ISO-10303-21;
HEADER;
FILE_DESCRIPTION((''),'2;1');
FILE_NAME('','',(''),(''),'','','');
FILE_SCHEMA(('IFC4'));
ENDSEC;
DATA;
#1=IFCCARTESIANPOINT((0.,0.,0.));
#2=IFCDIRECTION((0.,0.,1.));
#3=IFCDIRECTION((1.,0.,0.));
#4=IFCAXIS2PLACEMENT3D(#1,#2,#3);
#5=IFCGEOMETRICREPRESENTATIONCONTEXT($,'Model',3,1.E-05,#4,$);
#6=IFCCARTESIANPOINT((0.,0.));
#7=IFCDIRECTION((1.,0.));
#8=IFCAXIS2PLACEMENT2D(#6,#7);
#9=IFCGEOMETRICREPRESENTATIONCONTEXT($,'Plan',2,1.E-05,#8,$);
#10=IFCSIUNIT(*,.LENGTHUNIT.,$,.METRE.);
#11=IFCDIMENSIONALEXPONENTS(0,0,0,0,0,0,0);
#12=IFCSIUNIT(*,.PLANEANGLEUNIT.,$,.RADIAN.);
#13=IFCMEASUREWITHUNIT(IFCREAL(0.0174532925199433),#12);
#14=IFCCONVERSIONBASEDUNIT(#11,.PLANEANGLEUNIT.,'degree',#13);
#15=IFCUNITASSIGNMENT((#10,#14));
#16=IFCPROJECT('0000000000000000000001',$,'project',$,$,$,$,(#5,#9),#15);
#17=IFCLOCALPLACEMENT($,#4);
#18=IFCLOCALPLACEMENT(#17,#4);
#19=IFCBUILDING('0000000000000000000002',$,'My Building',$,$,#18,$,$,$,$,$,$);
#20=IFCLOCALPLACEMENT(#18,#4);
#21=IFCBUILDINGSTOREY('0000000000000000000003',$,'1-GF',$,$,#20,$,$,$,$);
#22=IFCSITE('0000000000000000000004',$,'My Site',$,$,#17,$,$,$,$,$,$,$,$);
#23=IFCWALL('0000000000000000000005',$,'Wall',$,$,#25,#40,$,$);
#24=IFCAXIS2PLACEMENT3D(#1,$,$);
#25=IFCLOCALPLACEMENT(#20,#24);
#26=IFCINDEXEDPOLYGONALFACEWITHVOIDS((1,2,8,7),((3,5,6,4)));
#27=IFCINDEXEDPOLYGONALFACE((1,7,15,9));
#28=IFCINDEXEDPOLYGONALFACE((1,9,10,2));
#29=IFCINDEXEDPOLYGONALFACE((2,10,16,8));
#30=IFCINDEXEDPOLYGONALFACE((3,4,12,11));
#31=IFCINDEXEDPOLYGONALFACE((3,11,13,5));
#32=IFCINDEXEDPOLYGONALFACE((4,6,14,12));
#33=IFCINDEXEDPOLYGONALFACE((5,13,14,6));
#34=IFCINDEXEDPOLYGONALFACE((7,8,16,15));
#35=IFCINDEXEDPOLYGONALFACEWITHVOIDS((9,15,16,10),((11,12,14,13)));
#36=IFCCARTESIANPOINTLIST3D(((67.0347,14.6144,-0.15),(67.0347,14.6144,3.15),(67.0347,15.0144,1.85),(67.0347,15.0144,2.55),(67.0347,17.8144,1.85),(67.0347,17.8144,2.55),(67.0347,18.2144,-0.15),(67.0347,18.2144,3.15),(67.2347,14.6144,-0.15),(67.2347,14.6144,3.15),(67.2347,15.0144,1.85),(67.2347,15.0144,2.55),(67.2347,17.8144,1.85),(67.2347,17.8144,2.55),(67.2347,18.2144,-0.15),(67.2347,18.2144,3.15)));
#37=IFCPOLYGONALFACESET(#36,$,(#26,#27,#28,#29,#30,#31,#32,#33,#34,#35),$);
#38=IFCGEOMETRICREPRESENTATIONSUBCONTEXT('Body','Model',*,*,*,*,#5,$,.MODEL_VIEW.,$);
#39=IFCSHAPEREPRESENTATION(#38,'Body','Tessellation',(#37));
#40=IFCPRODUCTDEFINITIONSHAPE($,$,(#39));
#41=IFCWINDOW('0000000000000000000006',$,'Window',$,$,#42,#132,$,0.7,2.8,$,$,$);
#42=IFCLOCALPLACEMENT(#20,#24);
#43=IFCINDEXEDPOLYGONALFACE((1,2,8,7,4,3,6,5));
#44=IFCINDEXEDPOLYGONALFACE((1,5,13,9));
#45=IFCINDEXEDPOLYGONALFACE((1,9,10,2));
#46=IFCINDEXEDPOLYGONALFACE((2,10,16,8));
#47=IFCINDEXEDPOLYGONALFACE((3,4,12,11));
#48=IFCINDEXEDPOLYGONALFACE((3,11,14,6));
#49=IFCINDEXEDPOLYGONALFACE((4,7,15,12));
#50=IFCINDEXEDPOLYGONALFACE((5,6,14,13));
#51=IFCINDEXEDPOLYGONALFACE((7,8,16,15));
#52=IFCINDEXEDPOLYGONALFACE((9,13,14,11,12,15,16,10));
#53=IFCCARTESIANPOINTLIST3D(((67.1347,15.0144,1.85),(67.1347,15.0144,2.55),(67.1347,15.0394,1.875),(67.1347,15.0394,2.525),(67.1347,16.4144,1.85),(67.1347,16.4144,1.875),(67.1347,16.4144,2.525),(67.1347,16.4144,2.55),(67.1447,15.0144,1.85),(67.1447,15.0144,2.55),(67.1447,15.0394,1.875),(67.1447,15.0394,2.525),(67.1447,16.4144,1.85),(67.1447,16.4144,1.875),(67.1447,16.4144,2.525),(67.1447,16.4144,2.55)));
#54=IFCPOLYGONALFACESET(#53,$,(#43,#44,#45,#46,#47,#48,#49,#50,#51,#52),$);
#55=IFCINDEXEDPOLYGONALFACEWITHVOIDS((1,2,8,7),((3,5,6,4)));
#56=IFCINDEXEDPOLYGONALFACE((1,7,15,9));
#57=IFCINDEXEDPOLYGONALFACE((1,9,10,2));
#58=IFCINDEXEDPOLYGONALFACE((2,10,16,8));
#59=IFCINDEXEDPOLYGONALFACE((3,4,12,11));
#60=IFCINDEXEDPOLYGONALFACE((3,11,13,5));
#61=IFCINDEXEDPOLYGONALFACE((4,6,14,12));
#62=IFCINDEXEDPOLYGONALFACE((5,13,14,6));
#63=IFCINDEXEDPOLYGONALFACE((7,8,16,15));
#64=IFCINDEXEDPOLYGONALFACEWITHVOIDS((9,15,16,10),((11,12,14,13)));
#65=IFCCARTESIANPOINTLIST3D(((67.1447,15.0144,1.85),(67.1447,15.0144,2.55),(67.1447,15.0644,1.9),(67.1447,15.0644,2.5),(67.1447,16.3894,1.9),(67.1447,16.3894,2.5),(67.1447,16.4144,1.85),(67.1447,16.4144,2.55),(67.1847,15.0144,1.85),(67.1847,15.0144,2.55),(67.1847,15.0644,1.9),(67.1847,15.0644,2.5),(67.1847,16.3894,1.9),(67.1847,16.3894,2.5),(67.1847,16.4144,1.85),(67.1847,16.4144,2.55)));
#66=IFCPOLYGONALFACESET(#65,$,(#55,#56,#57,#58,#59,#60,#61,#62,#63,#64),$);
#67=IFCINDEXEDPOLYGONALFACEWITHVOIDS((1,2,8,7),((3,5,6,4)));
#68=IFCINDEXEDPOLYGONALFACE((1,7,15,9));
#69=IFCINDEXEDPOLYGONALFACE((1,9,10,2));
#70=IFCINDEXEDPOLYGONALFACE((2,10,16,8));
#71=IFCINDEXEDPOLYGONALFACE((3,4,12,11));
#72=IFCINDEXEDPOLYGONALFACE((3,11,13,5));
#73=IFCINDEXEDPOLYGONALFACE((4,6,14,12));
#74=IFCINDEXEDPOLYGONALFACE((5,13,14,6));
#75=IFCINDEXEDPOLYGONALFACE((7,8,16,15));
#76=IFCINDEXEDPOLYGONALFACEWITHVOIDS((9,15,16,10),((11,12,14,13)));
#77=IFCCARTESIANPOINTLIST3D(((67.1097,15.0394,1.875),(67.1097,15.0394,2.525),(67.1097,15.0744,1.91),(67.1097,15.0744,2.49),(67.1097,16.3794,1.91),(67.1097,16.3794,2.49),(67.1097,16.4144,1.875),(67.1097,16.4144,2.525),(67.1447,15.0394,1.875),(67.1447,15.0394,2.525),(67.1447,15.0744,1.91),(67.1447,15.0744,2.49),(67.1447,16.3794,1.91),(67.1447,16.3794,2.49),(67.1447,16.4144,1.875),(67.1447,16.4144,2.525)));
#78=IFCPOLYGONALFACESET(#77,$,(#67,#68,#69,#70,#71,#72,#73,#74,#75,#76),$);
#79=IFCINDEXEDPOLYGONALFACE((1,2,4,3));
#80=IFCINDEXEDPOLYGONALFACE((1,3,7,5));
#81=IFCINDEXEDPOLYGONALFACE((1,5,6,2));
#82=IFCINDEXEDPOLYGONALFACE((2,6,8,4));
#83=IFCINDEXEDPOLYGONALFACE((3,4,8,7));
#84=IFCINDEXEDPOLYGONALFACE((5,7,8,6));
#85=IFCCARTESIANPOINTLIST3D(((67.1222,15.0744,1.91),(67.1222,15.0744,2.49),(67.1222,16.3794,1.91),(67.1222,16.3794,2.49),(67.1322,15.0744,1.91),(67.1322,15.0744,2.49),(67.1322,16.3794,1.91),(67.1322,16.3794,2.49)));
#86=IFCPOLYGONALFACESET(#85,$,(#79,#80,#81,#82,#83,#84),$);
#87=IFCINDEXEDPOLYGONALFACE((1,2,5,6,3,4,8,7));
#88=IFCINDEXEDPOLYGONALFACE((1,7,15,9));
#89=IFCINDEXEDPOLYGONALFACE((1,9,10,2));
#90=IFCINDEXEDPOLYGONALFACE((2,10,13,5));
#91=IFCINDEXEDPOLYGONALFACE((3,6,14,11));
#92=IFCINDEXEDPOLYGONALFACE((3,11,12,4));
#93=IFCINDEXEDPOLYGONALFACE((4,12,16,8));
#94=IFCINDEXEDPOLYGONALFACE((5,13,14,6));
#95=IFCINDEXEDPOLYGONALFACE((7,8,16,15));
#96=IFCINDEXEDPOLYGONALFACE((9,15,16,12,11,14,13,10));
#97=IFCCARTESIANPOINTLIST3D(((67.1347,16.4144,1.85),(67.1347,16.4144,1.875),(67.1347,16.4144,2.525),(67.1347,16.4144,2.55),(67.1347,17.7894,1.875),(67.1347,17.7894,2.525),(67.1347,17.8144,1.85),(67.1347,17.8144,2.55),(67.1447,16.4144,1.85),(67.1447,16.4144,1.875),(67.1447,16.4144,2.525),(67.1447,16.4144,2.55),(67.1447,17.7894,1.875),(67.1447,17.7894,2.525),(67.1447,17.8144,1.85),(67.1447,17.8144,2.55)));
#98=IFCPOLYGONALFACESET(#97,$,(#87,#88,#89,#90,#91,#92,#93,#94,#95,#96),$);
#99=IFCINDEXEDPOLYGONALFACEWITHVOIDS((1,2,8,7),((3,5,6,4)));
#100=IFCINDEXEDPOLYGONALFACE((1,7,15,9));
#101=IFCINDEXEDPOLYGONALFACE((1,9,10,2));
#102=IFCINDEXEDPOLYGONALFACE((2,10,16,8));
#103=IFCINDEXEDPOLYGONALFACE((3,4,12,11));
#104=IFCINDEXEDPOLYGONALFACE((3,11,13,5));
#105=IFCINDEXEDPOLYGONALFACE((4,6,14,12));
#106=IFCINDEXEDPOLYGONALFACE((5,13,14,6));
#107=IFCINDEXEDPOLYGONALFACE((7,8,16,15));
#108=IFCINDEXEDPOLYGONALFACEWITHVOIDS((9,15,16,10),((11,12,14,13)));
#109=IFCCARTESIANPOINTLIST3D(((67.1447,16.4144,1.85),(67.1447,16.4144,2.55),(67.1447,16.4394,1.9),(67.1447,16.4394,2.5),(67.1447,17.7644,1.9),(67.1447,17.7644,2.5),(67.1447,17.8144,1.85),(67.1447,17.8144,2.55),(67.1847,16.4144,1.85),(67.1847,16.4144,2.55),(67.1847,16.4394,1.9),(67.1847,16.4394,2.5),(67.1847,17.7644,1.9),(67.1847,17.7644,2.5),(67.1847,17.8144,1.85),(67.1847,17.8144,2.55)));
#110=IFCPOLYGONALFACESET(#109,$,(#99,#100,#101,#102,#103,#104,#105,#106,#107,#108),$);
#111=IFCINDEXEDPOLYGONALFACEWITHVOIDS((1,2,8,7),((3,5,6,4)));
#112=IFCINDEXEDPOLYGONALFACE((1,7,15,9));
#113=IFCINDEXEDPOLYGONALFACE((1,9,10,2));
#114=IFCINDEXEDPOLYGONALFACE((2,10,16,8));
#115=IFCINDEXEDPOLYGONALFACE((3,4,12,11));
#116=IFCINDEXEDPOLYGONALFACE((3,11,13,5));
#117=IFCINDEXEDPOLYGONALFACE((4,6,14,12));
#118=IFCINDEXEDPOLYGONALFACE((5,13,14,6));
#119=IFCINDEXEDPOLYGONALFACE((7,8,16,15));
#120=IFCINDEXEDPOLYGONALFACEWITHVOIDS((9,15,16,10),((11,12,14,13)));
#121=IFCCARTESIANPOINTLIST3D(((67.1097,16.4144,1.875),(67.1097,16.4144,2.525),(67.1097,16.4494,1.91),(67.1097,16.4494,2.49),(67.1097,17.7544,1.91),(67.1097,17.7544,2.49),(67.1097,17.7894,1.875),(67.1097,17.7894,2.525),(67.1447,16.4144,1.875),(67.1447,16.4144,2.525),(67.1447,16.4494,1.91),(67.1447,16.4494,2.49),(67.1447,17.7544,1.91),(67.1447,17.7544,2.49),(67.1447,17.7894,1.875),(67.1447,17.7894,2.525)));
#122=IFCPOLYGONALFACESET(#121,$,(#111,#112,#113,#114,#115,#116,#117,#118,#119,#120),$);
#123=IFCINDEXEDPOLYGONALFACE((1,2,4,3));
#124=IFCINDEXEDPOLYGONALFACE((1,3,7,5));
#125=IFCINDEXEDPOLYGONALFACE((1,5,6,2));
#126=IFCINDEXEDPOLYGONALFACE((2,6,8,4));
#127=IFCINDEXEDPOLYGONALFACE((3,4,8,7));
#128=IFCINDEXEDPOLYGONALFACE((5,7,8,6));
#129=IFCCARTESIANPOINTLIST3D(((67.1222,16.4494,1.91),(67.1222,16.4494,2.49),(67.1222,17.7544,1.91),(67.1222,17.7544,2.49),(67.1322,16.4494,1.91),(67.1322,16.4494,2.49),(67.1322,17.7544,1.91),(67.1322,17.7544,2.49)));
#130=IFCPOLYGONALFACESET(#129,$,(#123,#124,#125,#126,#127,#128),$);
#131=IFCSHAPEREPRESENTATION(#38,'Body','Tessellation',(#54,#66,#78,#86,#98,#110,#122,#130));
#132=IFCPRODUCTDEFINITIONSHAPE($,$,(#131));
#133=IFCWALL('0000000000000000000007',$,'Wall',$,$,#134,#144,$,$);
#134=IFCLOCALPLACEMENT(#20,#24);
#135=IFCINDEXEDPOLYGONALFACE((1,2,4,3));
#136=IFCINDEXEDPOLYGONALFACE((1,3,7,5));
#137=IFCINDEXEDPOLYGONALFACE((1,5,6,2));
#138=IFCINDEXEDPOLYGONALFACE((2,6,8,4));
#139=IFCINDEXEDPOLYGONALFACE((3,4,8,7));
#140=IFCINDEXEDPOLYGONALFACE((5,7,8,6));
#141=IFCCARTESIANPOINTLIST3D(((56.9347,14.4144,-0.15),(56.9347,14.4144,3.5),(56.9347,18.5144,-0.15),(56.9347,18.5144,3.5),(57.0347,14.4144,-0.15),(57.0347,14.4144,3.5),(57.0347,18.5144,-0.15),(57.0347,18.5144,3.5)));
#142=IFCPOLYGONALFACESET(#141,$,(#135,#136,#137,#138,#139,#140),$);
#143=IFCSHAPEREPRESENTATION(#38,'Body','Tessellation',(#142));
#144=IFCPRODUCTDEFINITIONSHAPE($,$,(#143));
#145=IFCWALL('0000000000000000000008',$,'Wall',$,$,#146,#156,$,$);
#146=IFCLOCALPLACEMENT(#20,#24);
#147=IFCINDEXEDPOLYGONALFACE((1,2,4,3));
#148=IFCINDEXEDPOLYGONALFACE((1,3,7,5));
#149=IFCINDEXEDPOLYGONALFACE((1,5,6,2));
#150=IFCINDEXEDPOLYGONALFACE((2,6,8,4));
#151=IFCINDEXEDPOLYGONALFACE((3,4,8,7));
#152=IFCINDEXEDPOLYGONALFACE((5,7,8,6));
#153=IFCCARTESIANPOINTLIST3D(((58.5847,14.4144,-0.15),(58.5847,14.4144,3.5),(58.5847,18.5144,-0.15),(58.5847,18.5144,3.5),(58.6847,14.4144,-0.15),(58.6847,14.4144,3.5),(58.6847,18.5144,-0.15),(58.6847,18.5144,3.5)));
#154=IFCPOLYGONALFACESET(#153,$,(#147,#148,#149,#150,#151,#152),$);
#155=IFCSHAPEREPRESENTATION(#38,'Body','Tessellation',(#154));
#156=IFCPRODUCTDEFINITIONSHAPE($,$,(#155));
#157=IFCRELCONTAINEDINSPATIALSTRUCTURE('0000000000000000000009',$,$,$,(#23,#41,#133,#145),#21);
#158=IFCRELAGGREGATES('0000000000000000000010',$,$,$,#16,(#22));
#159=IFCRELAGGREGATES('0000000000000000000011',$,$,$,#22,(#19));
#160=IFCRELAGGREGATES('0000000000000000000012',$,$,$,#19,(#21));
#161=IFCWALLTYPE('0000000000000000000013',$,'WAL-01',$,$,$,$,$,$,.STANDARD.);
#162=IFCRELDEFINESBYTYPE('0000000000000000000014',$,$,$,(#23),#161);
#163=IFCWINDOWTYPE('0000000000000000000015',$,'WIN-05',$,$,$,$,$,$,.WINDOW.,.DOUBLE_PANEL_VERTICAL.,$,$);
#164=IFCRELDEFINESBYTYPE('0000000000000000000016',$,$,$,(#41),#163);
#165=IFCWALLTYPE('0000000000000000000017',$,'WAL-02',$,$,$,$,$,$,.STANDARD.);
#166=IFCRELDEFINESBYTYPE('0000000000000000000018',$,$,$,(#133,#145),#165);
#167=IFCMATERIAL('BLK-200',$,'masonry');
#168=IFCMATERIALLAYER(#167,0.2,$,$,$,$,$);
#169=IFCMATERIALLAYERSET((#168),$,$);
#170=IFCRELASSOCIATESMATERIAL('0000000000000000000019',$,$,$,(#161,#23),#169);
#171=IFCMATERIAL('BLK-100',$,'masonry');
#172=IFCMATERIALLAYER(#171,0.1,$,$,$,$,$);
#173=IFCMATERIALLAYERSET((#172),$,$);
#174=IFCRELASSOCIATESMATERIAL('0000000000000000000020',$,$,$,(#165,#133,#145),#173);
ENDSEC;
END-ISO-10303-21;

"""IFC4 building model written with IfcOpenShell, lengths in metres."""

from ifc_helpers import new_model, entity, si_unit, converted_unit, frame, origin_with_axes, origin_2d_with_axis, place, context, subcontext, project, spatial, line, indexed_curve, outline, extrude, shape, source, transform, mapped, material, layer, layer_set, layer_usage, type_object, type_shapes, element, fill, save


model = new_model("IFC4")

# Units and contexts
model_context = context("Model", 3, precision=1e-05, world=origin_with_axes())
plan_context = context("Plan", 2, precision=1e-05, world=origin_2d_with_axis())
body_context_1 = subcontext(model_context, "Body", "Model", "MODEL_VIEW")
body_context_2 = subcontext(plan_context, "Body", "Plan", "PLAN_VIEW")
ifc_project = project(units=[si_unit("LENGTHUNIT", "METRE"), converted_unit("PLANEANGLEUNIT", "degree", entity("IfcReal", 0.0174532925199433), si_unit("PLANEANGLEUNIT", "RADIAN"), dimensions=[0, 0, 0, 0, 0, 0, 0])], contexts=[model_context, plan_context])

# Site, building, storey
site_placement = place(None, origin_with_axes())
site = spatial("IfcSite", under=ifc_project, at=site_placement, Name="My Site")
building_placement = place(site_placement, origin_with_axes())
building = spatial("IfcBuilding", under=site, at=building_placement, Name="My Building")
storey_placement = place(building_placement, origin_with_axes())
storey = spatial("IfcBuildingStorey", under=building, at=storey_placement, Name="1-GF")

# Shared definitions
ifc_material_1 = material(Name="BLK-200", Category="masonry")
ifc_layer_1 = layer(ifc_material_1, 0.2)
ifc_layer_set_1 = layer_set([ifc_layer_1])
wall_type_1 = type_object("IfcWallType", Name="WAL-01", PredefinedType="STANDARD", material=ifc_layer_set_1)

# Wall, opening, window
ifc_layer_usage_1 = layer_usage(ifc_layer_set_1, "AXIS2", "POSITIVE", 0.0)
wall_1_placement = place(storey_placement, frame((67.2347, 14.6144, -0.15), z_axis=(0.0, 0.0, 1.0), x_axis=(0.000001, 1.0, 0.0)))
wall_1 = element("IfcWall", 1, at=wall_1_placement, inside=storey, type_object=wall_type_1, material=ifc_layer_usage_1, Name="Wall", context=body_context_1, shape_type="SweptSolid", body=[
    extrude(outline(indexed_curve([(0.0, 0.0), (0.0, 0.2), (3.6, 0.2), (3.6, 0.0), (0.0, 0.0)], self_intersect=False)), origin_with_axes(), (0.0, 0.0, 1.0), 3.3),
])
shared_shape_1 = source(origin_with_axes(), body_context_1, "Body", "SweptSolid", [
    extrude(outline(indexed_curve([(0.0, 0.0), (2.8, 0.0), (2.8, 0.7), (0.0, 0.7)], segments=[line(1, 2, 3, 4, 1)])), frame((0.0, -0.6, 0.0), z_axis=(0.0, -1.0, 0.0), x_axis=(1.0, 0.0, 0.0)), (0.0, 0.0, -1.0), 1.2),
])
opening_1_placement = place(wall_1_placement, frame((0.4, 0.0, 2.0), z_axis=(0.0, 0.0, 1.0), x_axis=(1.0, 0.0, 0.0)))
opening_1 = element("IfcOpeningElement", 2, at=opening_1_placement, cuts=wall_1, PredefinedType="OPENING", context=body_context_1, shape_type="MappedRepresentation", body=[
    mapped(shared_shape_1, transform((0.0, 0.0, 0.0), x_axis=(1.0, 0.0, 0.0), y_axis=(0.0, 1.0, 0.0), z_axis=(0.0, 0.0, 1.0), scale=1.0)),
])
window_type = type_object("IfcWindowType", Name="WIN-05", PartitioningType="DOUBLE_PANEL_VERTICAL", PredefinedType="WINDOW")
shared_shape_2 = source(origin_with_axes(), body_context_1, "Body", "SweptSolid", [
    extrude(outline(indexed_curve([(1.4, 0.0), (0.0, 0.0), (0.0, 0.7), (1.4, 0.7), (1.4, 0.675), (0.025, 0.675), (0.025, 0.025), (1.4, 0.025)], segments=[line(1, 2, 3, 4, 5, 6, 7, 8, 1)])), frame((0.0, 0.09, 0.0), z_axis=(0.0, -1.0, 0.0), x_axis=(1.0, 0.0, 0.0)), (0.0, 0.0, -1.0), 0.01),
    extrude(outline(indexed_curve([(0.0, 0.0), (1.4, 0.0), (1.4, 0.7), (0.0, 0.7)], segments=[line(1, 2, 3, 4, 1)]), holes=[indexed_curve([(0.05, 0.05), (1.375, 0.05), (1.375, 0.65), (0.05, 0.65)], segments=[line(1, 2, 3, 4, 1)])]), frame((0.0, 0.05, 0.0), z_axis=(0.0, -1.0, 0.0), x_axis=(1.0, 0.0, 0.0)), (0.0, 0.0, -1.0), 0.04),
    extrude(outline(indexed_curve([(0.0, 0.0), (1.375, 0.0), (1.375, 0.65), (0.0, 0.65)], segments=[line(1, 2, 3, 4, 1)]), holes=[indexed_curve([(0.035, 0.035), (1.34, 0.035), (1.34, 0.615), (0.035, 0.615)], segments=[line(1, 2, 3, 4, 1)])]), frame((0.025, 0.09, 0.025), z_axis=(0.0, -1.0, 0.0), x_axis=(1.0, 0.0, 0.0)), (0.0, 0.0, -1.0), 0.035),
    extrude(outline(indexed_curve([(0.035, 0.035), (1.34, 0.035), (1.34, 0.615), (0.035, 0.615)], segments=[line(1, 2, 3, 4, 1)])), frame((0.025, 0.1025, 0.025), z_axis=(0.0, -1.0, 0.0), x_axis=(1.0, 0.0, 0.0)), (0.0, 0.0, -1.0), 0.01),
    extrude(outline(indexed_curve([(0.0, 0.7), (1.4, 0.7), (1.4, 0.0), (0.0, 0.0), (0.0, 0.025), (1.375, 0.025), (1.375, 0.675), (0.0, 0.675)], segments=[line(1, 2, 3, 4, 5, 6, 7, 8, 1)])), frame((1.4, 0.09, 0.0), z_axis=(0.0, -1.0, 0.0), x_axis=(1.0, 0.0, 0.0)), (0.0, 0.0, -1.0), 0.01),
    extrude(outline(indexed_curve([(0.0, 0.0), (1.4, 0.0), (1.4, 0.7), (0.0, 0.7)], segments=[line(1, 2, 3, 4, 1)]), holes=[indexed_curve([(0.025, 0.05), (1.35, 0.05), (1.35, 0.65), (0.025, 0.65)], segments=[line(1, 2, 3, 4, 1)])]), frame((1.4, 0.05, 0.0), z_axis=(0.0, -1.0, 0.0), x_axis=(1.0, 0.0, 0.0)), (0.0, 0.0, -1.0), 0.04),
    extrude(outline(indexed_curve([(0.0, 0.0), (1.375, 0.0), (1.375, 0.65), (0.0, 0.65)], segments=[line(1, 2, 3, 4, 1)]), holes=[indexed_curve([(0.035, 0.035), (1.34, 0.035), (1.34, 0.615), (0.035, 0.615)], segments=[line(1, 2, 3, 4, 1)])]), frame((1.4, 0.09, 0.025), z_axis=(0.0, -1.0, 0.0), x_axis=(1.0, 0.0, 0.0)), (0.0, 0.0, -1.0), 0.035),
    extrude(outline(indexed_curve([(0.035, 0.035), (1.34, 0.035), (1.34, 0.615), (0.035, 0.615)], segments=[line(1, 2, 3, 4, 1)])), frame((1.4, 0.1025, 0.025), z_axis=(0.0, -1.0, 0.0), x_axis=(1.0, 0.0, 0.0)), (0.0, 0.0, -1.0), 0.01),
])
shared_shape_3 = source(origin_with_axes(), body_context_2, "Body", "Curve2D", [
    entity("IfcIndexedPolyCurve", entity("IfcCartesianPointList2D", [[0.05, 0.05], [1.375, 0.05]])),
    entity("IfcIndexedPolyCurve", entity("IfcCartesianPointList2D", [[0.0, 0.1], [0.025, 0.1], [0.025, 0.09], [0.05, 0.09], [0.05, 0.05], [0.0, 0.05]]), [entity("IfcLineIndex", [1, 2, 3, 4, 5, 6, 1])]),
    entity("IfcIndexedPolyCurve", entity("IfcCartesianPointList2D", [[1.4, 0.1], [1.4, 0.1], [1.4, 0.09], [1.375, 0.09], [1.375, 0.05], [1.4, 0.05]])),
    entity("IfcIndexedPolyCurve", entity("IfcCartesianPointList2D", [[0.025, 0.09], [0.06, 0.09], [0.06, 0.125], [0.025, 0.125]]), [entity("IfcLineIndex", [1, 2, 3, 4, 1])]),
    entity("IfcIndexedPolyCurve", entity("IfcCartesianPointList2D", [[1.4, 0.09], [1.365, 0.09], [1.365, 0.125], [1.4, 0.125]]), [entity("IfcLineIndex", [1, 2, 3, 4, 1])]),
    entity("IfcIndexedPolyCurve", entity("IfcCartesianPointList2D", [[0.06, 0.09], [1.365, 0.09]])),
    entity("IfcIndexedPolyCurve", entity("IfcCartesianPointList2D", [[0.06, 0.125], [1.365, 0.125]])),
    entity("IfcIndexedPolyCurve", entity("IfcCartesianPointList2D", [[0.06, 0.1075], [1.365, 0.1075]])),
    entity("IfcIndexedPolyCurve", entity("IfcCartesianPointList2D", [[1.425, 0.05], [2.75, 0.05]])),
    entity("IfcIndexedPolyCurve", entity("IfcCartesianPointList2D", [[1.4, 0.1], [1.4, 0.1], [1.4, 0.09], [1.425, 0.09], [1.425, 0.05], [1.4, 0.05]])),
    entity("IfcIndexedPolyCurve", entity("IfcCartesianPointList2D", [[2.8, 0.1], [2.775, 0.1], [2.775, 0.09], [2.75, 0.09], [2.75, 0.05], [2.8, 0.05]]), [entity("IfcLineIndex", [1, 2, 3, 4, 5, 6, 1])]),
    entity("IfcIndexedPolyCurve", entity("IfcCartesianPointList2D", [[1.4, 0.09], [1.435, 0.09], [1.435, 0.125], [1.4, 0.125]]), [entity("IfcLineIndex", [1, 2, 3, 4, 1])]),
    entity("IfcIndexedPolyCurve", entity("IfcCartesianPointList2D", [[2.775, 0.09], [2.74, 0.09], [2.74, 0.125], [2.775, 0.125]]), [entity("IfcLineIndex", [1, 2, 3, 4, 1])]),
    entity("IfcIndexedPolyCurve", entity("IfcCartesianPointList2D", [[1.435, 0.09], [2.74, 0.09]])),
    entity("IfcIndexedPolyCurve", entity("IfcCartesianPointList2D", [[1.435, 0.125], [2.74, 0.125]])),
    entity("IfcIndexedPolyCurve", entity("IfcCartesianPointList2D", [[1.435, 0.1075], [2.74, 0.1075]])),
])
type_shapes(window_type, [shared_shape_2, shared_shape_3])
window_placement = place(opening_1_placement, frame((0.0, 0.0, 0.0), z_axis=(0.0, 0.0, 1.0), x_axis=(1.0, 0.0, 0.0)))
window = element("IfcWindow", 3, at=window_placement, inside=storey, type_object=window_type, Name="Window", OverallHeight=0.7, OverallWidth=2.8, shapes=[
    shape(body_context_1, "Body", "MappedRepresentation", [mapped(shared_shape_2, transform((0.0, 0.0, 0.0), x_axis=(1.0, 0.0, 0.0), y_axis=(0.0, 1.0, 0.0), z_axis=(0.0, 0.0, 1.0), scale=1.0))]),
    shape(body_context_2, "Body", "MappedRepresentation", [mapped(shared_shape_3, transform((0.0, 0.0, 0.0), x_axis=(1.0, 0.0, 0.0), y_axis=(0.0, 1.0, 0.0), z_axis=(0.0, 0.0, 1.0), scale=1.0))]),
])
fill(opening_1, window)

# Walls
ifc_material_2 = material(Name="BLK-100", Category="masonry")
ifc_layer_2 = layer(ifc_material_2, 0.1)
ifc_layer_set_2 = layer_set([ifc_layer_2])
ifc_layer_usage_2 = layer_usage(ifc_layer_set_2, "AXIS2", "POSITIVE", 0.0)
wall_type_2 = type_object("IfcWallType", Name="WAL-02", PredefinedType="STANDARD", material=ifc_layer_set_2)
wall_2_placement = place(storey_placement, frame((57.0347, 14.4144, -0.15), z_axis=(0.0, 0.0, 1.0), x_axis=(0.0, 1.0, 0.0)))
element("IfcWall", 4, at=wall_2_placement, inside=storey, type_object=wall_type_2, material=ifc_layer_usage_2, Name="Wall", context=body_context_1, shape_type="SweptSolid", body=[
    extrude(outline(indexed_curve([(0.0, 0.0), (0.0, 0.1), (4.1, 0.1), (4.1, 0.0), (0.0, 0.0)], self_intersect=False)), origin_with_axes(), (0.0, 0.0, 1.0), 3.65),
])
ifc_layer_usage_3 = layer_usage(ifc_layer_set_2, "AXIS2", "POSITIVE", 0.0)
wall_3_placement = place(storey_placement, frame((58.6847, 14.4144, -0.15), z_axis=(0.0, 0.0, 1.0), x_axis=(0.0, 1.0, 0.0)))
element("IfcWall", 5, at=wall_3_placement, inside=storey, type_object=wall_type_2, material=ifc_layer_usage_3, Name="Wall", context=body_context_1, shape_type="SweptSolid", body=[
    extrude(outline(indexed_curve([(0.0, 0.0), (0.0, 0.1), (4.1, 0.1), (4.1, 0.0), (0.0, 0.0)], self_intersect=False)), origin_with_axes(), (0.0, 0.0, 1.0), 3.65),
])

save(model, "model.ifc")
